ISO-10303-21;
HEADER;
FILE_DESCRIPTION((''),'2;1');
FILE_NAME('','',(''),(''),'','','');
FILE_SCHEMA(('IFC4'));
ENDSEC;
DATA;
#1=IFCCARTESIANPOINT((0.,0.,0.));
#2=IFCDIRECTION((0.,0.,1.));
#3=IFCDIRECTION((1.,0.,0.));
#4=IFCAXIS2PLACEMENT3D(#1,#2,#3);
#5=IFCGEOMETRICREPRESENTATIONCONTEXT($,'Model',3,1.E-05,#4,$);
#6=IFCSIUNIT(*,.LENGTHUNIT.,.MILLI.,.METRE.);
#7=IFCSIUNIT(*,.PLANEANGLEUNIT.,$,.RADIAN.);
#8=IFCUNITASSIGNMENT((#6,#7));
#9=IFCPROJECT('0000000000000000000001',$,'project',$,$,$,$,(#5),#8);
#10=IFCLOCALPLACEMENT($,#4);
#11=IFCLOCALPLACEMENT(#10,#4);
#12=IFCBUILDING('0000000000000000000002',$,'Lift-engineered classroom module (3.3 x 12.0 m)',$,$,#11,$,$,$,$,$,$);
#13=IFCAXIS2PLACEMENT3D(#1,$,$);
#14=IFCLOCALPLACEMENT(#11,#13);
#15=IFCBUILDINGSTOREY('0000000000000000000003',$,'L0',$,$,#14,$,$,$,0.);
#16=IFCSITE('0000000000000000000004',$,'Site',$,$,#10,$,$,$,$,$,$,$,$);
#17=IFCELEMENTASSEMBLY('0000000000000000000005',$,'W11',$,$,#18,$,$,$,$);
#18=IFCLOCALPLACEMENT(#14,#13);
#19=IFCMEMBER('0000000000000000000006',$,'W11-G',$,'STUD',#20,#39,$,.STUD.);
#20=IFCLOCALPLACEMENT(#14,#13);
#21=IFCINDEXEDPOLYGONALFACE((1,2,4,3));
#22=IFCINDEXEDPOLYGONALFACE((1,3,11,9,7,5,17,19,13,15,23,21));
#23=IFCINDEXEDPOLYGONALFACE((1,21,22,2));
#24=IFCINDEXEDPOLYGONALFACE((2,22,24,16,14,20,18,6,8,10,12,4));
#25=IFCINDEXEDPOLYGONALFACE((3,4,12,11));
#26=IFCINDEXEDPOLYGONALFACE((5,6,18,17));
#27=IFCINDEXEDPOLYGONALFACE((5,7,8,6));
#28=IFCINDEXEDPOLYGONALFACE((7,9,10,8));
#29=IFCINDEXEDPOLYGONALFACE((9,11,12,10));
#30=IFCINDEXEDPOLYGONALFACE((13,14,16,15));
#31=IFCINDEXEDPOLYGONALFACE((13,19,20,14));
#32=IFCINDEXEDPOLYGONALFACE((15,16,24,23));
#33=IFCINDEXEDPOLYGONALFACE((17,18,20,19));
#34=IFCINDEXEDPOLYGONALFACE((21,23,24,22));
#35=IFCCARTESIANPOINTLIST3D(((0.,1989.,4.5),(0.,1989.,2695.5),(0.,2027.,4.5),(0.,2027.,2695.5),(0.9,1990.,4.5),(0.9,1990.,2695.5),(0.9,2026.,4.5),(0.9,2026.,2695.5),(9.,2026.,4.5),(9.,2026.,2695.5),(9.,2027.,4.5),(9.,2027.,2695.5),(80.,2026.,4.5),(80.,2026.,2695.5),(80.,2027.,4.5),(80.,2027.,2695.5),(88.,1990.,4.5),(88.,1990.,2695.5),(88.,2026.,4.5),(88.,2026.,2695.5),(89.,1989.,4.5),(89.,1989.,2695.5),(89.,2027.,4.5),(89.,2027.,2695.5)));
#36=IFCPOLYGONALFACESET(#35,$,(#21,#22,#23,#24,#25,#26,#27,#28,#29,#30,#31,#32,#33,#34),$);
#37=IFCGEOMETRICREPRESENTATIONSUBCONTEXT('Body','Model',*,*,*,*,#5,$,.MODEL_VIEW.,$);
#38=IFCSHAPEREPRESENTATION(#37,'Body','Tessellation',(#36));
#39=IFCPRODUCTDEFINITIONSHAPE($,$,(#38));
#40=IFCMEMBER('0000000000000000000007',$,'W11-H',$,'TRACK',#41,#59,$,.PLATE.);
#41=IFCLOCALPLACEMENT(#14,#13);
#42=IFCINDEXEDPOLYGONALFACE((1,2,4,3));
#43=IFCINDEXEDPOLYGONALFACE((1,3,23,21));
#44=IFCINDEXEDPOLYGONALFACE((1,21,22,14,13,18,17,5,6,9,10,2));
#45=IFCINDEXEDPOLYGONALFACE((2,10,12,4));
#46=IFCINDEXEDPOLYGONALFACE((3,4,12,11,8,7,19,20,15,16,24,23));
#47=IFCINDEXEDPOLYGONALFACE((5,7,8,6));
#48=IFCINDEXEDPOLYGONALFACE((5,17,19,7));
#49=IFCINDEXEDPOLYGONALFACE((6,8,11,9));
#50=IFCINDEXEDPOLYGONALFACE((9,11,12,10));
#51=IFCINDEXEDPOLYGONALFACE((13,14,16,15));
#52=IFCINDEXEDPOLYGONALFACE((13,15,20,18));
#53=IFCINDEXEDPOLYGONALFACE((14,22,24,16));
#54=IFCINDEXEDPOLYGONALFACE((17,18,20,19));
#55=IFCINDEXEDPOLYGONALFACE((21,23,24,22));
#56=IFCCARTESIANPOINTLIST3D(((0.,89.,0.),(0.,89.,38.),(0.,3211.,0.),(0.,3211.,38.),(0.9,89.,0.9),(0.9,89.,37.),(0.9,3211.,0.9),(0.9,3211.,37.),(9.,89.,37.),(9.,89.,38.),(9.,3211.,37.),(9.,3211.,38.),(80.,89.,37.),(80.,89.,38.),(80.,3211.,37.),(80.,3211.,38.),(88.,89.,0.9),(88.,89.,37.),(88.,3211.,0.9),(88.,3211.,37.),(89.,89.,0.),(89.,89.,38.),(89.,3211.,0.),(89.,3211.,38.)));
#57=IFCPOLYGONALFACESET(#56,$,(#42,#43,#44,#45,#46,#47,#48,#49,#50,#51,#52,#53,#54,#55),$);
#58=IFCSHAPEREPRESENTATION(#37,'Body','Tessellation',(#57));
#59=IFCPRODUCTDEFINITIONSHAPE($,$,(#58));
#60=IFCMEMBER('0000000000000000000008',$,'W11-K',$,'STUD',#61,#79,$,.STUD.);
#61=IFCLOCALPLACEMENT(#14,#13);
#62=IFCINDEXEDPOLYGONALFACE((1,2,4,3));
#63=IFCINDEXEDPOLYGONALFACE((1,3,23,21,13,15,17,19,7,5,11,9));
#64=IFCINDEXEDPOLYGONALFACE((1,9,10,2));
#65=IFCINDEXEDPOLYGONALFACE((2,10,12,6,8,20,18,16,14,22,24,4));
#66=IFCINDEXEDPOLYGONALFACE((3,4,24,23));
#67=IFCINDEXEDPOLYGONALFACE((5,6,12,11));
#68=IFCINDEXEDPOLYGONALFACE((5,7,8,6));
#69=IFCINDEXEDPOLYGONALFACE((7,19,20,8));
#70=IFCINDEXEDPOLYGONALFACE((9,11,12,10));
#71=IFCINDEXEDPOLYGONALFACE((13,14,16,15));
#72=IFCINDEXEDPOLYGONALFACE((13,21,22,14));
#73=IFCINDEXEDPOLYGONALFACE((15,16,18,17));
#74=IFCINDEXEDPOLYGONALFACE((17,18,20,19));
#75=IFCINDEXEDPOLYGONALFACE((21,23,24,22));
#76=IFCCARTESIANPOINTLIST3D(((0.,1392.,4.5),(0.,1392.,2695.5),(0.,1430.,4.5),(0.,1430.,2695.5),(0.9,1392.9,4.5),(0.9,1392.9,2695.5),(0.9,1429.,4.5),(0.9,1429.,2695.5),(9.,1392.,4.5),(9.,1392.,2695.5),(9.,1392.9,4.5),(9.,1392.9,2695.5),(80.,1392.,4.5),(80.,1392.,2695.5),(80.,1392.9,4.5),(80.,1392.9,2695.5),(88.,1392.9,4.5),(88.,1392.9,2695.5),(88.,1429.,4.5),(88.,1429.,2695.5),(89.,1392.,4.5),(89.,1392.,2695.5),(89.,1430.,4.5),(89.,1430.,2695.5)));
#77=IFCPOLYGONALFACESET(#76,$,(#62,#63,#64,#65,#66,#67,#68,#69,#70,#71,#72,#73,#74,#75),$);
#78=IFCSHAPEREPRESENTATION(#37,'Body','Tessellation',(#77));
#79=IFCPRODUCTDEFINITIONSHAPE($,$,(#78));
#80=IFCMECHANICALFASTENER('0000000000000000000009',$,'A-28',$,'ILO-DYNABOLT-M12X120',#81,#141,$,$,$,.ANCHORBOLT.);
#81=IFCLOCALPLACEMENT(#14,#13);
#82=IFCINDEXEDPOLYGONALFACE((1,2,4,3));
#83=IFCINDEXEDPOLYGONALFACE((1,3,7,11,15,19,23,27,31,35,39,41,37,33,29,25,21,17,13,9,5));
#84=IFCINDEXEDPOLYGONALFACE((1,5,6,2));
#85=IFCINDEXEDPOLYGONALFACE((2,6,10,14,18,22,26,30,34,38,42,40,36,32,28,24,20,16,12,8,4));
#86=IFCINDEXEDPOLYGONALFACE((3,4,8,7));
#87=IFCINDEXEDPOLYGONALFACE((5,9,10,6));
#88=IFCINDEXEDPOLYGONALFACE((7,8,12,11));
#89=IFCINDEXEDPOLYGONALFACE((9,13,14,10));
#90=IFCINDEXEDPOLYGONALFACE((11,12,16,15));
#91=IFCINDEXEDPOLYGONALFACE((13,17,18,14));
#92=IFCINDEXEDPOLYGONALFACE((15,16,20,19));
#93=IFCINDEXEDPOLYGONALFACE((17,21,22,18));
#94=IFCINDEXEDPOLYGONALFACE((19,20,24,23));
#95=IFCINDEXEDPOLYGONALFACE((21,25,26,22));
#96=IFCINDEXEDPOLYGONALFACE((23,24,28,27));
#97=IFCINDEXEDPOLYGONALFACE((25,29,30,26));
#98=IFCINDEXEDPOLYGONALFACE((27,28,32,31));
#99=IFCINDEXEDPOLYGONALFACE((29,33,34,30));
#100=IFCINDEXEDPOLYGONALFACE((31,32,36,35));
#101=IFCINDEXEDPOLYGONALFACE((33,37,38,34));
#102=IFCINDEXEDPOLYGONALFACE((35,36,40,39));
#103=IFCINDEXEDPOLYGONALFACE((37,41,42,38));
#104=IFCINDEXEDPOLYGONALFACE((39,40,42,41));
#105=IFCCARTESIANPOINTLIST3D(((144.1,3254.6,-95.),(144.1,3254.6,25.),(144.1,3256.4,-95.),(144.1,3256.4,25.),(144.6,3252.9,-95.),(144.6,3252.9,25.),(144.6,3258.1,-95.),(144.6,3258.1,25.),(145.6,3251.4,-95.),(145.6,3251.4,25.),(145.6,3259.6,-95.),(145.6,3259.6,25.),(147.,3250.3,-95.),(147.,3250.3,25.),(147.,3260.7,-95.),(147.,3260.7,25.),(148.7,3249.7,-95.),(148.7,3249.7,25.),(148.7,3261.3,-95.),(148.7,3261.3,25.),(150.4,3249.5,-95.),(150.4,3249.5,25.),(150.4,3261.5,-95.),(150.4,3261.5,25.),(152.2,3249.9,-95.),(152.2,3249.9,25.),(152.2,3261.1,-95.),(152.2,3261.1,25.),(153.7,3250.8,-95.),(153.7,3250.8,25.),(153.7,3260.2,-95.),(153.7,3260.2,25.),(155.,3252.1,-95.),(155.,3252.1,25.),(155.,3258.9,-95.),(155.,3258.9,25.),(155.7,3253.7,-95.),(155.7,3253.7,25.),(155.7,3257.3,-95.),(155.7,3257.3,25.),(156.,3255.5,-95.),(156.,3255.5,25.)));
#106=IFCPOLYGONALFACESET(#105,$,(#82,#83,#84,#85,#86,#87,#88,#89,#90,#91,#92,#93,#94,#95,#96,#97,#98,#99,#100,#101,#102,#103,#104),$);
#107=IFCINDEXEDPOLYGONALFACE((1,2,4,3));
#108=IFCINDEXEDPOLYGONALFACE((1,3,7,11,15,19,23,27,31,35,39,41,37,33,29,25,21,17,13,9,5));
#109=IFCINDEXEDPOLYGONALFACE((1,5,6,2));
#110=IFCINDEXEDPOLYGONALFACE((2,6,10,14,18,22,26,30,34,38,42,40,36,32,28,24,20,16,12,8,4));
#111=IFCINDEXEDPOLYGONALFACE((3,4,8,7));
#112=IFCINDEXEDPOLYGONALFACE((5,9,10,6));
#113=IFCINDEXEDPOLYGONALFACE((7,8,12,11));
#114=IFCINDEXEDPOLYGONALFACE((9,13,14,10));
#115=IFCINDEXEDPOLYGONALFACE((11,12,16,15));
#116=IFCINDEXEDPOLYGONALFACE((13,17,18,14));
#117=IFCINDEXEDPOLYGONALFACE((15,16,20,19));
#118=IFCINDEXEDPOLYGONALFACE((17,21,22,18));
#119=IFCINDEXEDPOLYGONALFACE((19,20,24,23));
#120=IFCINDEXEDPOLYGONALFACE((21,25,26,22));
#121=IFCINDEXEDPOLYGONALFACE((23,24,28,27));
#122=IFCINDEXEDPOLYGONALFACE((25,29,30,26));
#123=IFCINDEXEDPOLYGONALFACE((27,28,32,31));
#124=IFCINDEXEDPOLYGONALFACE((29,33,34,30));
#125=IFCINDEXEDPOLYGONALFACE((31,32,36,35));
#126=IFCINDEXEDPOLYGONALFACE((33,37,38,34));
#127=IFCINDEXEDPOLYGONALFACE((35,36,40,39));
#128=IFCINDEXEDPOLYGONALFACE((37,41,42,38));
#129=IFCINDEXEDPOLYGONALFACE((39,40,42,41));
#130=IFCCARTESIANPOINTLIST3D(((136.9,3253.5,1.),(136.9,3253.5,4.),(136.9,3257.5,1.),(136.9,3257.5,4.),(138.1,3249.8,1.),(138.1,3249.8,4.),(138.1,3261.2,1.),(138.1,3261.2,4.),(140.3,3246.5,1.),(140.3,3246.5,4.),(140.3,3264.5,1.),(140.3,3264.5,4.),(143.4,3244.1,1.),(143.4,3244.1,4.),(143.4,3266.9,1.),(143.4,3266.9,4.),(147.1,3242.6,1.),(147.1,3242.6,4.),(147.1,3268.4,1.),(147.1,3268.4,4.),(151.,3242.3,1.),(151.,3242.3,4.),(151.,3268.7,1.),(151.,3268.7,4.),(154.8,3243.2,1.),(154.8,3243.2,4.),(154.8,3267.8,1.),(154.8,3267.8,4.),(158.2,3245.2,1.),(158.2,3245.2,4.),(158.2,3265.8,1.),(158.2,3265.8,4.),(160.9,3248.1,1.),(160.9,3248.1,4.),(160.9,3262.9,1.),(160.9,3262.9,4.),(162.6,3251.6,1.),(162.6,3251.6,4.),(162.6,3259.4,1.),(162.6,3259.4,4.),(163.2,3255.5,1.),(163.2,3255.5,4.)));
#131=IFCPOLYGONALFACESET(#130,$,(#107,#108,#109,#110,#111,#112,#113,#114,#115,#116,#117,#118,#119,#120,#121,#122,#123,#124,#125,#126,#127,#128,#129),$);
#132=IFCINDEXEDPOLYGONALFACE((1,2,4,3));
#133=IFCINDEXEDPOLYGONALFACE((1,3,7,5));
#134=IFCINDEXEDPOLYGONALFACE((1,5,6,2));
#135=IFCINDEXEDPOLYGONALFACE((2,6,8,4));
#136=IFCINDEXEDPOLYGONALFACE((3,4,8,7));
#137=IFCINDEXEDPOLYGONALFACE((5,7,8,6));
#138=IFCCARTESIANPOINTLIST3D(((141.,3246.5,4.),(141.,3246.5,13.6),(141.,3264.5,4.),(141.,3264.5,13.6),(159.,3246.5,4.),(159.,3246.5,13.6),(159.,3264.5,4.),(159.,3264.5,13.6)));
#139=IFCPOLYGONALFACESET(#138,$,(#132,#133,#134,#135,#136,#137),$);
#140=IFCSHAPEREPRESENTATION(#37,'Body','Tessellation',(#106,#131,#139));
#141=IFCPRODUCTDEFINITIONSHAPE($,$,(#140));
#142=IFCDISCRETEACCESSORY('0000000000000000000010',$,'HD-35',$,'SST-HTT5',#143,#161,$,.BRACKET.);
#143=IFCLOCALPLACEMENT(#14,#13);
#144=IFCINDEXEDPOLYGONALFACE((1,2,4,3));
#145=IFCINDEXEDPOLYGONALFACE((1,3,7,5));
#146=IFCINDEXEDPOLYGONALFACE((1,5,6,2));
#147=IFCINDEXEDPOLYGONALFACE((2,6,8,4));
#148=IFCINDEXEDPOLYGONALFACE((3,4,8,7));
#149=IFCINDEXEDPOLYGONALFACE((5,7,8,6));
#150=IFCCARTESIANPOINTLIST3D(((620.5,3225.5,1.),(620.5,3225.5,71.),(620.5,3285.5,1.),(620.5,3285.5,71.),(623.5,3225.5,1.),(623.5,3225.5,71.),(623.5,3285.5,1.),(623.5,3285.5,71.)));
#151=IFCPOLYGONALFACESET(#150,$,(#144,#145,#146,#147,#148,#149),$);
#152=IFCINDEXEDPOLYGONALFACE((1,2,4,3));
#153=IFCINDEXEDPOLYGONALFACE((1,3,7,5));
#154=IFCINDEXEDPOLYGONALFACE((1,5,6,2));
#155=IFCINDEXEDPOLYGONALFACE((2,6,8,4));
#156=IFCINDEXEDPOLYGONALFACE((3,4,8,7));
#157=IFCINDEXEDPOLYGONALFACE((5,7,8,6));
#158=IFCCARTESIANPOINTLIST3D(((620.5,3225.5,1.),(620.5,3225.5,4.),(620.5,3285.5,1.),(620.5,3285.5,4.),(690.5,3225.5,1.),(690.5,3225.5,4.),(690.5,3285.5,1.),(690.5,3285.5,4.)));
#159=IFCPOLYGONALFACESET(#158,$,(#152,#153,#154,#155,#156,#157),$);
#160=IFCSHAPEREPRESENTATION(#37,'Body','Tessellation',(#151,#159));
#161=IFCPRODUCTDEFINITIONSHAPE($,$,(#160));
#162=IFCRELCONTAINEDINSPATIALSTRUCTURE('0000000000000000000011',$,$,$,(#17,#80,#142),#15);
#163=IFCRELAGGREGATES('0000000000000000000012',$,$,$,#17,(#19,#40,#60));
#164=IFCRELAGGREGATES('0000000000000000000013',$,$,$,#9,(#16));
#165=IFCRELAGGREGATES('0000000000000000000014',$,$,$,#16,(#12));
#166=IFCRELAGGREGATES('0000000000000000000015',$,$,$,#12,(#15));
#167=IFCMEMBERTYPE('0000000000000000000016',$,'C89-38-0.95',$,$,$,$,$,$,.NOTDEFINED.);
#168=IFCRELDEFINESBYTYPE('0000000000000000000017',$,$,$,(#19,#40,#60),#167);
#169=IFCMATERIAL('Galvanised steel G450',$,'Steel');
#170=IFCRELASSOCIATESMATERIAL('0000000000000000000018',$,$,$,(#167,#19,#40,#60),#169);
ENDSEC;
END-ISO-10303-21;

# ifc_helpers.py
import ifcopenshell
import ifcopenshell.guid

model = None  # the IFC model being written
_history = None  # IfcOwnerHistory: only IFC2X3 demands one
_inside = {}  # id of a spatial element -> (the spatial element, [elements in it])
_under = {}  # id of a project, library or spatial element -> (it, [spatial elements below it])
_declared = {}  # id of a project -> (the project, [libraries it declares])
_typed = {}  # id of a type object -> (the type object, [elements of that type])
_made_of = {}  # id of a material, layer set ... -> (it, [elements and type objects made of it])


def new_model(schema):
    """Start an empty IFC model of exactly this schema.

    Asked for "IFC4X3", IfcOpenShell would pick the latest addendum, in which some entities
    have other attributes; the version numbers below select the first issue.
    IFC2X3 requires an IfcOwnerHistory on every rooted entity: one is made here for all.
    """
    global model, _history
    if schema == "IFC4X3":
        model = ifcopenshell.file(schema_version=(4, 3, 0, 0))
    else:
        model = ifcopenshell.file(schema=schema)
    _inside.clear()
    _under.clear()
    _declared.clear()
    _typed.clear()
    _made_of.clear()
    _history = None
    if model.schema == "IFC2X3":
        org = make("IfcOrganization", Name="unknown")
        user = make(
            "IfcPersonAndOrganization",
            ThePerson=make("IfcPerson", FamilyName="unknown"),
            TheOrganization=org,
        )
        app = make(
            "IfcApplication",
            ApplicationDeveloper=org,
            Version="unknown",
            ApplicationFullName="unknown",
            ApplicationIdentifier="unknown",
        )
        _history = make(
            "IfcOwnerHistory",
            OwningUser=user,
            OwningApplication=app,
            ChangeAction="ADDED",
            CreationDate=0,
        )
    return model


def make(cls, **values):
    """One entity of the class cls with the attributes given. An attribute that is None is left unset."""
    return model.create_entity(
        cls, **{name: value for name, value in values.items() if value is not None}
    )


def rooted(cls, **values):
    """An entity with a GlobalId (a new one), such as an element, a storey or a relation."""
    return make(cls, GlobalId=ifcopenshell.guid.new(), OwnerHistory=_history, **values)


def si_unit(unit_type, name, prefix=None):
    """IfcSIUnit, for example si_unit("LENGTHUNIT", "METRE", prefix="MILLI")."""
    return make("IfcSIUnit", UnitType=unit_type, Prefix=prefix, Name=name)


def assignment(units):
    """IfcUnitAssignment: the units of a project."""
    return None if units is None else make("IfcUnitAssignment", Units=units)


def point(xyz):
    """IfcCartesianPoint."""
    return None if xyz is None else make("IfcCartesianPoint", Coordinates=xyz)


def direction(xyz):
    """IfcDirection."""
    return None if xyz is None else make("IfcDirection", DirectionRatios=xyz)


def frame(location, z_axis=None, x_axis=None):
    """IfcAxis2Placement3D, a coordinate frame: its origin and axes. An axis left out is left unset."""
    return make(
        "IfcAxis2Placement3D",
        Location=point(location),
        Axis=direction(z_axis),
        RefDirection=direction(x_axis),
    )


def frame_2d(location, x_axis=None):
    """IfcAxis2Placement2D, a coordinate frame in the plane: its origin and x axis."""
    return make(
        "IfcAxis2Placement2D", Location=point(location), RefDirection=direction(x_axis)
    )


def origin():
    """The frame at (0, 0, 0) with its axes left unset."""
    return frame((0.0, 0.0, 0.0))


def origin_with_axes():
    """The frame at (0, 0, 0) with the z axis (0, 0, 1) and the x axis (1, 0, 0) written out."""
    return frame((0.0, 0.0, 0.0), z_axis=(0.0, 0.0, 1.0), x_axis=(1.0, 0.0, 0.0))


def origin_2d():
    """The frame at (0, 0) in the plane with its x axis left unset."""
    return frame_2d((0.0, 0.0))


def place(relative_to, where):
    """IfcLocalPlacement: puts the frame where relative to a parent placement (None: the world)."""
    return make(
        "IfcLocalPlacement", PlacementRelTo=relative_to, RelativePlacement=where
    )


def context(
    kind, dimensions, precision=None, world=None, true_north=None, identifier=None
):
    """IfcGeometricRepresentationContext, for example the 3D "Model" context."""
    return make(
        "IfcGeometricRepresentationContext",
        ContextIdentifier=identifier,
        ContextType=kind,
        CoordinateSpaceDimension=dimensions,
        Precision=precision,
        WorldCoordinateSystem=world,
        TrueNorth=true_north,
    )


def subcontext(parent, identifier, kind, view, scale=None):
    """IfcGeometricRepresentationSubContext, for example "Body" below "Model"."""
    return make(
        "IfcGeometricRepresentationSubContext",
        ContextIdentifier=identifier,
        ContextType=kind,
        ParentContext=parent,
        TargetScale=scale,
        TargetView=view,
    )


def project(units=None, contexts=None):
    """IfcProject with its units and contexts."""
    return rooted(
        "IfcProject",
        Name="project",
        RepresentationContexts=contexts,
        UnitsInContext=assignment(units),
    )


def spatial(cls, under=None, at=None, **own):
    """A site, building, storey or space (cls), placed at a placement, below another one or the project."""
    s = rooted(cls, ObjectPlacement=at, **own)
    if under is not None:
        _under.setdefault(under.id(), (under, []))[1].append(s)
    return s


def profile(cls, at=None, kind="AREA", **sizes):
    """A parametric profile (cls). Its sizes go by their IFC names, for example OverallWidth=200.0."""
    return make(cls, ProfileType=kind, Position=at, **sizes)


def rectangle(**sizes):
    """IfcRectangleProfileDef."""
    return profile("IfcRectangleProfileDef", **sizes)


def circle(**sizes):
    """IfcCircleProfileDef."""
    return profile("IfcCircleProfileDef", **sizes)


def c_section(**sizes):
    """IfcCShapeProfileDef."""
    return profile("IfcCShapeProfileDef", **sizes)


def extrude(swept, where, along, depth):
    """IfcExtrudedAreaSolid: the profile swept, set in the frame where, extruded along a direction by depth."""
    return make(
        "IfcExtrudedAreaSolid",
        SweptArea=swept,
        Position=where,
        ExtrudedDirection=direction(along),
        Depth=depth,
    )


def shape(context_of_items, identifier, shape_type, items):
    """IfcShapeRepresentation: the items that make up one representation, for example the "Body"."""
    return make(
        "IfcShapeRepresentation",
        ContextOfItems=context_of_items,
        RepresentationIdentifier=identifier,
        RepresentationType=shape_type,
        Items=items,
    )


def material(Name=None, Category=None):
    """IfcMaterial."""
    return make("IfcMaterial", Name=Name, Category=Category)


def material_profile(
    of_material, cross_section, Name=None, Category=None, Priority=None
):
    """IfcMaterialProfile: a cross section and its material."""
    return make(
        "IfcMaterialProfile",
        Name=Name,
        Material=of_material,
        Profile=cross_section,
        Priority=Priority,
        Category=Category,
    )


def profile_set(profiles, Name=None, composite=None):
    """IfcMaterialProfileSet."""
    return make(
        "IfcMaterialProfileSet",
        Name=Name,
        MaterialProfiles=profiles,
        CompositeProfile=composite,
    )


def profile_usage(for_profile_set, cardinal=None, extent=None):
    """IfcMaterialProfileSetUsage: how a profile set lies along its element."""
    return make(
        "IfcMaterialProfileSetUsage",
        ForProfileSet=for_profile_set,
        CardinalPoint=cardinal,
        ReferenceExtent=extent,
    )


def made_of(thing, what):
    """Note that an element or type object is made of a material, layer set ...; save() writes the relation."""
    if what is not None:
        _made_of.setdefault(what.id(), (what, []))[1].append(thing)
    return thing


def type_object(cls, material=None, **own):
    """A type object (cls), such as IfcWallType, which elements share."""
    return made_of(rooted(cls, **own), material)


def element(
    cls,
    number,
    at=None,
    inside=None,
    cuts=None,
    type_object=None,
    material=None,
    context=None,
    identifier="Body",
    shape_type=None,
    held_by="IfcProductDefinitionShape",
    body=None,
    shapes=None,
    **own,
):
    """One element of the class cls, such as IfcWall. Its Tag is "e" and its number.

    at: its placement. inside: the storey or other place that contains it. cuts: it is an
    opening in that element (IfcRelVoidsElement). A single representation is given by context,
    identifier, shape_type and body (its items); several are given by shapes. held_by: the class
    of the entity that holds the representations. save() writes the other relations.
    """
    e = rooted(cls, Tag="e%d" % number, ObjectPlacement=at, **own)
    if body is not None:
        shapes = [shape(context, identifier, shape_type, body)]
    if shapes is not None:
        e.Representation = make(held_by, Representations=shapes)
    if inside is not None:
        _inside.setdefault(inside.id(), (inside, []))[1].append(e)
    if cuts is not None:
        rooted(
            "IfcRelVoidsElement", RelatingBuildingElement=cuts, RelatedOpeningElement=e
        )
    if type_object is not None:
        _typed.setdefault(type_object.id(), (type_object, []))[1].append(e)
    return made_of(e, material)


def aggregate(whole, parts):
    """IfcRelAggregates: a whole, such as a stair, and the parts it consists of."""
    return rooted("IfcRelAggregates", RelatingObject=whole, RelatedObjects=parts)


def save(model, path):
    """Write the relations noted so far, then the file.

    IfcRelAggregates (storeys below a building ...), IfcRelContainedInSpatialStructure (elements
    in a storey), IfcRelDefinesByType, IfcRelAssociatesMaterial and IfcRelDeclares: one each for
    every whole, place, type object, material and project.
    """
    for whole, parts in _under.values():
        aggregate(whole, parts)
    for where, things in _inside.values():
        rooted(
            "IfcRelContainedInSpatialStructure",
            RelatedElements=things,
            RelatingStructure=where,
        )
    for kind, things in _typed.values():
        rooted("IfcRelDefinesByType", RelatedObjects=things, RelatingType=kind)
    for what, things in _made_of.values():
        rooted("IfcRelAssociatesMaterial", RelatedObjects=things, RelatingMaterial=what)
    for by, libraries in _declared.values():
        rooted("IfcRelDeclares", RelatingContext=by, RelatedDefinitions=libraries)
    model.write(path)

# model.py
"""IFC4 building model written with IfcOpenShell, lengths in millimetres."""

from ifc_helpers import new_model, si_unit, frame, frame_2d, origin, origin_with_axes, origin_2d, place, context, subcontext, project, spatial, rectangle, circle, c_section, extrude, material, material_profile, profile_set, profile_usage, type_object, element, aggregate, save


model = new_model("IFC4")

# Units and contexts
model_context = context("Model", 3, precision=1e-05, world=origin_with_axes())
body_context = subcontext(model_context, "Body", "Model", "MODEL_VIEW")
ifc_project = project(units=[si_unit("LENGTHUNIT", "METRE", prefix="MILLI"), si_unit("PLANEANGLEUNIT", "RADIAN")], contexts=[model_context])

# Site, building, storey
site_placement = place(None, origin_with_axes())
site = spatial("IfcSite", under=ifc_project, at=site_placement, Name="Site")
building_placement = place(site_placement, origin_with_axes())
building = spatial("IfcBuilding", under=site, at=building_placement, Name="Lift-engineered classroom module (3.3 x 12.0 m)")
storey_placement = place(building_placement, origin())
storey = spatial("IfcBuildingStorey", under=building, at=storey_placement, Name="L0", Elevation=0.0)

# Element assembly, members
ifc_material = material(Name="Galvanised steel G450", Category="Steel")
ifc_material_profile = material_profile(ifc_material, c_section(Depth=89.0, Width=38.0, WallThickness=0.9, Girth=9.0, at=origin_2d()), Name="C89-38-0.95")
ifc_profile_set = profile_set([ifc_material_profile], Name="C89-38-0.95")
ifc_profile_usage = profile_usage(ifc_profile_set)
member_type = type_object("IfcMemberType", Name="C89-38-0.95", PredefinedType="NOTDEFINED", material=ifc_profile_set)
assembly_1_placement = place(storey_placement, frame((44.5, 3211.0, 0.0)))
assembly_1 = element("IfcElementAssembly", 1, at=assembly_1_placement, inside=storey, Name="W11")
member_1_placement = place(assembly_1_placement, frame((0.0, -1203.0, 4.5), z_axis=(0.0, 0.0, 1.0), x_axis=(0.0, 1.0, 0.0)))
member_1 = element("IfcMember", 2, at=member_1_placement, type_object=member_type, material=ifc_profile_usage, Name="W11-G", ObjectType="STUD", PredefinedType="STUD", context=body_context, shape_type="SweptSolid", body=[
    extrude(c_section(Depth=89.0, Width=38.0, WallThickness=0.9, Girth=9.0, at=origin_2d()), origin(), (0.0, 0.0, 1.0), 2691.0),
])
member_2_placement = place(assembly_1_placement, frame((0.0, 0.0, 19.0), z_axis=(0.0, -1.0, 0.0), x_axis=(0.0, 0.0, 1.0)))
member_2 = element("IfcMember", 3, at=member_2_placement, type_object=member_type, material=ifc_profile_usage, Name="W11-H", ObjectType="TRACK", PredefinedType="PLATE", context=body_context, shape_type="SweptSolid", body=[
    extrude(c_section(Depth=89.0, Width=38.0, WallThickness=0.9, Girth=9.0, at=origin_2d()), origin(), (0.0, 0.0, 1.0), 3122.0),
])
member_3_placement = place(assembly_1_placement, frame((0.0, -1800.0, 2695.5), z_axis=(0.0, 0.0, -1.0), x_axis=(0.0, -1.0, 0.0)))
member_3 = element("IfcMember", 4, at=member_3_placement, type_object=member_type, material=ifc_profile_usage, Name="W11-K", ObjectType="STUD", PredefinedType="STUD", context=body_context, shape_type="SweptSolid", body=[
    extrude(c_section(Depth=89.0, Width=38.0, WallThickness=0.9, Girth=9.0, at=origin_2d()), origin(), (0.0, 0.0, 1.0), 2691.0),
])
aggregate(assembly_1, [member_1, member_2, member_3])

# Mechanical fastener
mechanical_fastener_1_placement = place(None, frame((150.0, 3255.5, 0.0), z_axis=(0.0, 0.0, 1.0), x_axis=(1.0, 0.0, 0.0)))
element("IfcMechanicalFastener", 5, at=mechanical_fastener_1_placement, inside=storey, Name="A-28", ObjectType="ILO-DYNABOLT-M12X120", PredefinedType="ANCHORBOLT", context=body_context, shape_type="SweptSolid", body=[
    extrude(circle(Radius=6.0, at=origin_2d()), frame((0.0, 0.0, -95.0), z_axis=(0.0, 0.0, 1.0), x_axis=(1.0, 0.0, 0.0)), (0.0, 0.0, 1.0), 120.0),
    extrude(circle(Radius=13.2, at=origin_2d()), frame((0.0, 0.0, 1.0), z_axis=(0.0, 0.0, 1.0), x_axis=(1.0, 0.0, 0.0)), (0.0, 0.0, 1.0), 3.0),
    extrude(rectangle(XDim=18.0, YDim=18.0, at=origin_2d()), frame((0.0, 0.0, 4.0), z_axis=(0.0, 0.0, 1.0), x_axis=(1.0, 0.0, 0.0)), (0.0, 0.0, 1.0), 9.6),
])

# Discrete accessory
discrete_accessory_1_placement = place(None, frame((620.5, 3255.5, 0.0), z_axis=(0.0, 0.0, 1.0), x_axis=(1.0, 0.0, 0.0)))
element("IfcDiscreteAccessory", 6, at=discrete_accessory_1_placement, inside=storey, Name="HD-35", ObjectType="SST-HTT5", PredefinedType="BRACKET", context=body_context, shape_type="SweptSolid", body=[
    extrude(rectangle(XDim=3.0, YDim=60.0, at=frame_2d((1.5, 0.0))), frame((0.0, 0.0, 1.0), z_axis=(0.0, 0.0, 1.0), x_axis=(1.0, 0.0, 0.0)), (0.0, 0.0, 1.0), 70.0),
    extrude(rectangle(XDim=70.0, YDim=60.0, at=frame_2d((35.0, 0.0))), frame((0.0, 0.0, 1.0), z_axis=(0.0, 0.0, 1.0), x_axis=(1.0, 0.0, 0.0)), (0.0, 0.0, 1.0), 3.0),
])

save(model, "model.ifc")
